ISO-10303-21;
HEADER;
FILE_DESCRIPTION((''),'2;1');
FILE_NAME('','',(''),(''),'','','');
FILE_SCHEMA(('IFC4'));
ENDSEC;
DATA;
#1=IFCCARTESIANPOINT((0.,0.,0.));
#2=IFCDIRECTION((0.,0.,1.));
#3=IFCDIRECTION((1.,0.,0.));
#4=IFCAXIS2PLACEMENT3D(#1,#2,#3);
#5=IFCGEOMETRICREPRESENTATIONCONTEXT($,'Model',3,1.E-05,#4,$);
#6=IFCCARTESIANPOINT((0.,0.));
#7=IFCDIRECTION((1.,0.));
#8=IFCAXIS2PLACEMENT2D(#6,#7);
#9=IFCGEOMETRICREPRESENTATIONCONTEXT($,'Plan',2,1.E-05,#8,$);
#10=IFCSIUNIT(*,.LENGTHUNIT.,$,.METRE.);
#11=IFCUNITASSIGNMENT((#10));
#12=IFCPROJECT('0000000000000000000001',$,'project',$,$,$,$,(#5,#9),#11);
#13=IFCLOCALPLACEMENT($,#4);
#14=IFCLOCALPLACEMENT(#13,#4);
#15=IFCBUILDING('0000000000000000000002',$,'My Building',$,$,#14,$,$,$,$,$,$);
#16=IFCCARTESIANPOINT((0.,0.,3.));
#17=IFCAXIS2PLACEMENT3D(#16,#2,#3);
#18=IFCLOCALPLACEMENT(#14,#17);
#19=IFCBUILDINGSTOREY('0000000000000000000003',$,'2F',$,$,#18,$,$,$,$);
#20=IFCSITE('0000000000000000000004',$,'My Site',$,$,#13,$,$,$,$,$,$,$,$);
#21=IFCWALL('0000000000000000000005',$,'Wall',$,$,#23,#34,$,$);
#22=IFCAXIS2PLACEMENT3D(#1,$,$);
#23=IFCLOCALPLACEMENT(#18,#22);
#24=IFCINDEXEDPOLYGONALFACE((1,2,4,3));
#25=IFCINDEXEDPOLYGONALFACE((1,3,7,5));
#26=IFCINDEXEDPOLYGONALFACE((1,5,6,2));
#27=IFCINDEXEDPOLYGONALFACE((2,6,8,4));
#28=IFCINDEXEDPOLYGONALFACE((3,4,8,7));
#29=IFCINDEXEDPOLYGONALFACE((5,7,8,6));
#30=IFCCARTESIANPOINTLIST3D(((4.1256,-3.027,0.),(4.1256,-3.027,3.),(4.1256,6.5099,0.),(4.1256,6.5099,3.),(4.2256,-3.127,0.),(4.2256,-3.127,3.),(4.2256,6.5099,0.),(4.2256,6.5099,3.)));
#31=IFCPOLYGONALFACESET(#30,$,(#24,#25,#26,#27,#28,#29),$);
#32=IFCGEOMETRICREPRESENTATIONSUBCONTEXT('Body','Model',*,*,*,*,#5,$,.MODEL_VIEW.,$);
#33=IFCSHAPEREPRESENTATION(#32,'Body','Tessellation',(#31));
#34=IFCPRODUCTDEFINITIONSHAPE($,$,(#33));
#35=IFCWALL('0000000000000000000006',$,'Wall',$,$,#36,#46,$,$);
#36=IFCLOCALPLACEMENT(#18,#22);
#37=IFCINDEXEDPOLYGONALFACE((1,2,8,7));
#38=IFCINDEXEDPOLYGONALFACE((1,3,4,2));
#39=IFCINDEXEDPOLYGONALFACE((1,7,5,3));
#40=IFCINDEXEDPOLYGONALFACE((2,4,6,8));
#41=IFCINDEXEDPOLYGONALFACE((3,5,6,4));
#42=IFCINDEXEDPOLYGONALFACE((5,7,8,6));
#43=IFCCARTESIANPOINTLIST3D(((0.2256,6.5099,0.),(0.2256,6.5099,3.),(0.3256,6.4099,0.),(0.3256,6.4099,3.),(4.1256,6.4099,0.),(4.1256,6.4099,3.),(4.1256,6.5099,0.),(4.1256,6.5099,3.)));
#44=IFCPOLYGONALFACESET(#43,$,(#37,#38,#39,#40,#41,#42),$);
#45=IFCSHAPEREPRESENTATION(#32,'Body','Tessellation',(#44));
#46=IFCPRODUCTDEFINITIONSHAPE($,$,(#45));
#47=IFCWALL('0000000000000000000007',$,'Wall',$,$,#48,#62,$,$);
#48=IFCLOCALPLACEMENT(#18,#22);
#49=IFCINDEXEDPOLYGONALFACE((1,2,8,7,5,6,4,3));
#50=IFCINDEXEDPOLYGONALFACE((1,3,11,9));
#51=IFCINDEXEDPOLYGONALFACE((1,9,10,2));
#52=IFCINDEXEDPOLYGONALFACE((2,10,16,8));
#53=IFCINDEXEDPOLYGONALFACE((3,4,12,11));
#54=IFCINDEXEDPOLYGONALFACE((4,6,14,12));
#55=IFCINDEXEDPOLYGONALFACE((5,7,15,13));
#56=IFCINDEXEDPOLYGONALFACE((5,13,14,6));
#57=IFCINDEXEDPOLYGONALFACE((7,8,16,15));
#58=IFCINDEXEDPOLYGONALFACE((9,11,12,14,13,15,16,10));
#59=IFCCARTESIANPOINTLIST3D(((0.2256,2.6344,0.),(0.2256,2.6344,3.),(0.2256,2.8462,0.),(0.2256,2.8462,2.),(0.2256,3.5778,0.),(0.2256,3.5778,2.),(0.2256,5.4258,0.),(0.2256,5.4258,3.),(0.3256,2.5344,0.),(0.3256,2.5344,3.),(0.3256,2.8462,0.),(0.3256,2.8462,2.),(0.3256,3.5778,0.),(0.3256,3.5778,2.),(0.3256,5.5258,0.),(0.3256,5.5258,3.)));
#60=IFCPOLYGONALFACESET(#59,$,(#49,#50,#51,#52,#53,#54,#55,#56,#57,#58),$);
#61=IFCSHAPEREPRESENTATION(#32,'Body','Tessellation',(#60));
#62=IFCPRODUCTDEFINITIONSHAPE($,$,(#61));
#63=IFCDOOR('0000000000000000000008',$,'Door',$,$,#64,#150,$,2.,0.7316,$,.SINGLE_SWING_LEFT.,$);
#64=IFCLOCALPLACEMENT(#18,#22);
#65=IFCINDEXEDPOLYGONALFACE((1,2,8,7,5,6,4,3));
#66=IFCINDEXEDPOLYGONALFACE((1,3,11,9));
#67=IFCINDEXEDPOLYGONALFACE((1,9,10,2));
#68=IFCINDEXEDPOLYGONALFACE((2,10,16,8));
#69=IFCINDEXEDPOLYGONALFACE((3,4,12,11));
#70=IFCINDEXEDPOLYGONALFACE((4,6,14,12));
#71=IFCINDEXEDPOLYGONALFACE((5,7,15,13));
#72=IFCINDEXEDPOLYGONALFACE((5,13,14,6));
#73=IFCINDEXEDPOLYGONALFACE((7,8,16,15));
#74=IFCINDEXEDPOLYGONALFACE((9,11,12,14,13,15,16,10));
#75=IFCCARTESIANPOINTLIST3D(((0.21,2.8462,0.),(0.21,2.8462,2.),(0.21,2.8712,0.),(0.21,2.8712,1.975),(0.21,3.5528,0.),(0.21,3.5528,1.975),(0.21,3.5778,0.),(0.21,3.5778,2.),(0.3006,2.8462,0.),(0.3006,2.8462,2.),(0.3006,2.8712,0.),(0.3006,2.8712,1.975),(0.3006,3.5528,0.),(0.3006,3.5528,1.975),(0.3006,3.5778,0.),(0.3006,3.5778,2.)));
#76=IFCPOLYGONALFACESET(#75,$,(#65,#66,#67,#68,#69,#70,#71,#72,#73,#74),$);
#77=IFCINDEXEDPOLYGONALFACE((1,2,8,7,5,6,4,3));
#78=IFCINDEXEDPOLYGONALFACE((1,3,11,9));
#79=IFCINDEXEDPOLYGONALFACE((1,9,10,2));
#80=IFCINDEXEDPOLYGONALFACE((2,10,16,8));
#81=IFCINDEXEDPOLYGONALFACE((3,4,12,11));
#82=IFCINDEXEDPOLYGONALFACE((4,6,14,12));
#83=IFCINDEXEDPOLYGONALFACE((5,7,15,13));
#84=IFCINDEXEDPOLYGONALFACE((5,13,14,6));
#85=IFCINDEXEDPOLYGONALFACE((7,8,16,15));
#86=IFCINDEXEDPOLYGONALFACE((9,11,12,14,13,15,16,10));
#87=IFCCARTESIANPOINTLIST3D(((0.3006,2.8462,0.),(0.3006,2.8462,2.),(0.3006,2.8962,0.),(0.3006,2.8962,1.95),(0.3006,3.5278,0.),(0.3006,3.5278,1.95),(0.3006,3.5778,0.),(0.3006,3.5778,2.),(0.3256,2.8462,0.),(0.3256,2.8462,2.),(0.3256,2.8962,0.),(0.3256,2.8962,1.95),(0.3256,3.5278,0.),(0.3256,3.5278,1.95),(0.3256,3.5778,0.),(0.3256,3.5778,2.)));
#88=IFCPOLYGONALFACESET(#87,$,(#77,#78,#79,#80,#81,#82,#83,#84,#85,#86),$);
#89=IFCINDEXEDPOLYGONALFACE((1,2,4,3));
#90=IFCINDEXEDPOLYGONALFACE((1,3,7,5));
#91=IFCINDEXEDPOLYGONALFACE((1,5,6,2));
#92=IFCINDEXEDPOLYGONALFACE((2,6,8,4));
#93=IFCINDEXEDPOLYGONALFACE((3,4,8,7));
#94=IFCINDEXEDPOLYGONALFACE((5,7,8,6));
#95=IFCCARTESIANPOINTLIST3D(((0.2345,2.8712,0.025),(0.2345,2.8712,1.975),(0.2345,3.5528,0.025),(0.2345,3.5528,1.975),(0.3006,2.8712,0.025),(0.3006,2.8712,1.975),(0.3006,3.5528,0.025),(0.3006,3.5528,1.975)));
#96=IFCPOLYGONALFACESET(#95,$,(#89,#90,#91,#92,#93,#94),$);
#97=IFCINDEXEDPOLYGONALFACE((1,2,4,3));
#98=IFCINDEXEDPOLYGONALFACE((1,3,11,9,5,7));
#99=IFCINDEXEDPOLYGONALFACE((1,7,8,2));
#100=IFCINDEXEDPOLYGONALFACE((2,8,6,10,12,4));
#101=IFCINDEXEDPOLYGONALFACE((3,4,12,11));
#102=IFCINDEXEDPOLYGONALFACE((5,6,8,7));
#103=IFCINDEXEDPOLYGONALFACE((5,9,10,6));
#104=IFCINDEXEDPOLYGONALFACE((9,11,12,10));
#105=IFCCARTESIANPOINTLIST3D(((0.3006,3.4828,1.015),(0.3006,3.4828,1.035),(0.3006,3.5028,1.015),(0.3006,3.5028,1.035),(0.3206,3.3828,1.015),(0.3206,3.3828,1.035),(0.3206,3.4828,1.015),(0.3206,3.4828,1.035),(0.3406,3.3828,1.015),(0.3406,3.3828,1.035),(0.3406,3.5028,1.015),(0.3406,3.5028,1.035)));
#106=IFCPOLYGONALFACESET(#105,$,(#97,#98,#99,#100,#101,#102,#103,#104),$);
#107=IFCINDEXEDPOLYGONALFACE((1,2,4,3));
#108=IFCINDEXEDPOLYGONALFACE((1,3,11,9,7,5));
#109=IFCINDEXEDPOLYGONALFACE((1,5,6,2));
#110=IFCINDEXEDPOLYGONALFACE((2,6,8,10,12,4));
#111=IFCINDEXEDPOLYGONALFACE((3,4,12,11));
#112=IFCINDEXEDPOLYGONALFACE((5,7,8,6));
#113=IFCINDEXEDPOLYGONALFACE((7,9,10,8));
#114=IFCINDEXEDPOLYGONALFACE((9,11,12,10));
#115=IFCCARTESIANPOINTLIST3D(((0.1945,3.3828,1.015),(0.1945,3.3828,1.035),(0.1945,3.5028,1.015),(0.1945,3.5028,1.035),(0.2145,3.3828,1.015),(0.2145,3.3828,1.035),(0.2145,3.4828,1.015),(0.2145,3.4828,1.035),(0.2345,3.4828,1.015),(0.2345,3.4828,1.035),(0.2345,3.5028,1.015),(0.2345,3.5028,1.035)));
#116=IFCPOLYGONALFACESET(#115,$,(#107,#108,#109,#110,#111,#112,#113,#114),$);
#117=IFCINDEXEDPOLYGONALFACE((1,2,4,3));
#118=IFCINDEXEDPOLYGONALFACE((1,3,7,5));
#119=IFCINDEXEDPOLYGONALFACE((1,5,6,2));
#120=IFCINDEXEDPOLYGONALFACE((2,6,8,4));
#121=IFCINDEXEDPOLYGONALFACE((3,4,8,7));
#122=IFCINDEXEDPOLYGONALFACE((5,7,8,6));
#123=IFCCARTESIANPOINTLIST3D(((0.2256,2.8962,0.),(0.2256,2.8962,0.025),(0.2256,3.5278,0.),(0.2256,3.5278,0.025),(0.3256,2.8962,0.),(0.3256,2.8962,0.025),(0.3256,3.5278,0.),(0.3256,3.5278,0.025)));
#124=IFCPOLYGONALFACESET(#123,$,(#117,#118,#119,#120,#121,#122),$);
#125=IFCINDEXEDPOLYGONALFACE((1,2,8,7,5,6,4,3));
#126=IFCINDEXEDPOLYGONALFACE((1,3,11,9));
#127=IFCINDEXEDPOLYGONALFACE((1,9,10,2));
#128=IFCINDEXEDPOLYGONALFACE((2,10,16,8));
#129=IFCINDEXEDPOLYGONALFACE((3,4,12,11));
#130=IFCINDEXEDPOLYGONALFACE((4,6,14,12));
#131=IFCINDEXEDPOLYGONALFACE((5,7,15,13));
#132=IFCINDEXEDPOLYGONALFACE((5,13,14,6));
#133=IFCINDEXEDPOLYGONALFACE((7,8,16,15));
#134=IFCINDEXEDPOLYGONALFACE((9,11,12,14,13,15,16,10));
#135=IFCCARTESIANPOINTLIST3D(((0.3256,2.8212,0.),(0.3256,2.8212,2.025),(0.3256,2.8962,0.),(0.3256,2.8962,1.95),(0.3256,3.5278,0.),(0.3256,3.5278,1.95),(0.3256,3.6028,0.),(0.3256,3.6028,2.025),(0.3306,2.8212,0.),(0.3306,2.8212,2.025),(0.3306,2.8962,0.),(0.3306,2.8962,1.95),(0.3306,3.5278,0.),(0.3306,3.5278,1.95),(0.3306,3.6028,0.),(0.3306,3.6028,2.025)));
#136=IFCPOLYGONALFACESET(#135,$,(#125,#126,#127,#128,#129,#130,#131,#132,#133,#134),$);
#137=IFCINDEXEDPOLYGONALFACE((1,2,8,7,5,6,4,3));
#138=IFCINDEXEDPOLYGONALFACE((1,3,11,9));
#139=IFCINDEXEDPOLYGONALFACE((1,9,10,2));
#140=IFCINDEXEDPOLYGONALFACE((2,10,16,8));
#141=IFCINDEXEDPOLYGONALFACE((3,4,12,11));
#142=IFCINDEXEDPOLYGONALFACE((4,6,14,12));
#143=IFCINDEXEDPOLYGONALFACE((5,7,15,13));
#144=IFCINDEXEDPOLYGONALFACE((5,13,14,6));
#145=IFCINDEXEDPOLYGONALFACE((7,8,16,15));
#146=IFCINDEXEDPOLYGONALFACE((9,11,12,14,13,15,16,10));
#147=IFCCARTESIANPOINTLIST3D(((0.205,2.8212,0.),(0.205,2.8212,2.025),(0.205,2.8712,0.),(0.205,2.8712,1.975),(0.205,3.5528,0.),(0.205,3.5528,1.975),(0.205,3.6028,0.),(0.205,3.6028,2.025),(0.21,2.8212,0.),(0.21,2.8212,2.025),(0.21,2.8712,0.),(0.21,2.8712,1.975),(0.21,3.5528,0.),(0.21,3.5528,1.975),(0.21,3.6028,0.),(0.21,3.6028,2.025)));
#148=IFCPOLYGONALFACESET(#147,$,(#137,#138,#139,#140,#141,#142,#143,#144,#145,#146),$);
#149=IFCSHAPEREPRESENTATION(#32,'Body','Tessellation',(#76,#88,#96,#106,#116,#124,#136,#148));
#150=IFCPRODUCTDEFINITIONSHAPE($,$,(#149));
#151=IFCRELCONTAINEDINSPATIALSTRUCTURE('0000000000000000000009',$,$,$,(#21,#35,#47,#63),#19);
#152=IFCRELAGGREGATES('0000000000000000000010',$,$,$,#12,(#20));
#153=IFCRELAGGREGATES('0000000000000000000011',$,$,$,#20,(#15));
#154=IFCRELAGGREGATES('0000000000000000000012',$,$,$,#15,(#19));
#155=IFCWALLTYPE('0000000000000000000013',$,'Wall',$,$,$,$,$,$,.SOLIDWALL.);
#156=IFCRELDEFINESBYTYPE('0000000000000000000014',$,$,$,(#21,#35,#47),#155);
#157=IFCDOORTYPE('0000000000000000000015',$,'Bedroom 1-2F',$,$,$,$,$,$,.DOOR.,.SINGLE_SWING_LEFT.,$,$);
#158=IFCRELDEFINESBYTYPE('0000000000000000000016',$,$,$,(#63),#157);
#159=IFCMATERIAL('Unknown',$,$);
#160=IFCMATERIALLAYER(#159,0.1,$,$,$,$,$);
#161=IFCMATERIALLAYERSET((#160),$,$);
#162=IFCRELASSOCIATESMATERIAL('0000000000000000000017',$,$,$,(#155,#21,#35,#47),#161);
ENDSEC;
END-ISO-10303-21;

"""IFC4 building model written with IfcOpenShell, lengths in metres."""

from ifc_helpers import new_model, entity, si_unit, frame, origin_with_axes, origin_2d_with_axis, place, context, subcontext, project, spatial, line, indexed_curve, outline, extrude, shape, source, transform, mapped, material, layer, layer_set, layer_usage, type_object, type_shapes, element, fill, save


model = new_model("IFC4")

# Units and contexts
model_context = context("Model", 3, precision=1e-05, world=origin_with_axes())
plan_context = context("Plan", 2, precision=1e-05, world=origin_2d_with_axis())
body_context_1 = subcontext(model_context, "Body", "Model", "MODEL_VIEW")
body_context_2 = subcontext(plan_context, "Body", "Plan", "PLAN_VIEW")
ifc_project = project(units=[si_unit("LENGTHUNIT", "METRE")], contexts=[model_context, plan_context])

# Site, building, storey
site_placement = place(None, origin_with_axes())
site = spatial("IfcSite", under=ifc_project, at=site_placement, Name="My Site")
building_placement = place(site_placement, origin_with_axes())
building = spatial("IfcBuilding", under=site, at=building_placement, Name="My Building")
storey_placement = place(building_placement, frame((0.0, 0.0, 3.0), z_axis=(0.0, 0.0, 1.0), x_axis=(1.0, 0.0, 0.0)))
storey = spatial("IfcBuildingStorey", under=building, at=storey_placement, Name="2F")

# Walls
ifc_material = material(Name="Unknown")
ifc_layer = layer(ifc_material, 0.1)
ifc_layer_set = layer_set([ifc_layer])
ifc_layer_usage_1 = layer_usage(ifc_layer_set, "AXIS2", "POSITIVE", 0.0)
wall_type = type_object("IfcWallType", Name="Wall", PredefinedType="SOLIDWALL", material=ifc_layer_set)
wall_1_placement = place(storey_placement, frame((4.2256, -3.127, 0.0), z_axis=(0.0, 0.0, 1.0), x_axis=(0.0, 1.0, 0.0)))
element("IfcWall", 1, at=wall_1_placement, inside=storey, type_object=wall_type, material=ifc_layer_usage_1, Name="Wall", context=body_context_1, shape_type="SweptSolid", body=[
    extrude(outline(indexed_curve([(0.0, 0.0), (0.1, 0.1), (9.6369, 0.1), (9.6369, 0.0)], segments=[line(1, 2, 3, 4, 1)])), origin_with_axes(), (0.0, 0.0, 1.0), 3.0),
])
ifc_layer_usage_2 = layer_usage(ifc_layer_set, "AXIS2", "POSITIVE", 0.0)
wall_2_placement = place(storey_placement, frame((4.1256, 6.5099, 0.0), z_axis=(0.0, 0.0, 1.0), x_axis=(-1.0, 0.0, 0.0)))
element("IfcWall", 2, at=wall_2_placement, inside=storey, type_object=wall_type, material=ifc_layer_usage_2, Name="Wall", context=body_context_1, shape_type="SweptSolid", body=[
    extrude(outline(indexed_curve([(0.0, 0.0), (0.0, 0.1), (3.8, 0.1), (3.9, 0.0)], segments=[line(1, 2, 3, 4, 1)])), origin_with_axes(), (0.0, 0.0, 1.0), 3.0),
])

# Wall, opening, door
ifc_layer_usage_3 = layer_usage(ifc_layer_set, "AXIS2", "POSITIVE", 0.0)
wall_3_placement = place(storey_placement, frame((0.2256, 5.5258, 0.0), z_axis=(0.0, 0.0, 1.0), x_axis=(0.0, -1.0, 0.0)))
wall_3 = element("IfcWall", 3, at=wall_3_placement, inside=storey, type_object=wall_type, material=ifc_layer_usage_3, Name="Wall", context=body_context_1, shape_type="SweptSolid", body=[
    extrude(outline(indexed_curve([(0.1, 0.0), (0.0, 0.1), (2.9914, 0.1), (2.8914, 0.0)], segments=[line(1, 2, 3, 4, 1)])), origin_with_axes(), (0.0, 0.0, 1.0), 3.0),
])
shared_shape_1 = source(origin_with_axes(), body_context_1, "Body", "SweptSolid", [
    extrude(outline(indexed_curve([(0.0, 0.0), (0.7316, 0.0), (0.7316, 2.0), (0.0, 2.0)], segments=[line(1, 2, 3, 4, 1)])), frame((0.0, -0.6, 0.0), z_axis=(0.0, -1.0, 0.0), x_axis=(1.0, 0.0, 0.0)), (0.0, 0.0, -1.0), 1.2),
])
opening_1_placement = place(wall_3_placement, frame((2.6795, 0.1, 0.0), z_axis=(0.0, 0.0, 1.0), x_axis=(-1.0, 0.0, 0.0)))
opening_1 = element("IfcOpeningElement", 4, at=opening_1_placement, cuts=wall_3, PredefinedType="OPENING", context=body_context_1, shape_type="MappedRepresentation", body=[
    mapped(shared_shape_1, transform((0.0, 0.0, 0.0), x_axis=(1.0, 0.0, 0.0), y_axis=(0.0, 1.0, 0.0), z_axis=(0.0, 0.0, 1.0), scale=1.0)),
])
door_type_1 = type_object("IfcDoorType", Name="Bedroom 1-2F", OperationType="SINGLE_SWING_LEFT", PredefinedType="DOOR")
shared_shape_2 = source(origin_with_axes(), body_context_1, "Body", "SweptSolid", [
    extrude(outline(indexed_curve([(0.0, 0.0), (0.0, 2.0), (0.7316, 2.0), (0.7316, 0.0), (0.7066, 0.0), (0.7066, 1.975), (0.025, 1.975), (0.025, 0.0)], segments=[line(1, 2, 3, 4, 5, 6, 7, 8, 1)])), frame((0.0, 0.025, 0.0), z_axis=(0.0, -1.0, 0.0), x_axis=(1.0, 0.0, 0.0)), (0.0, 0.0, -1.0), 0.0906),
    extrude(outline(indexed_curve([(0.0, 0.0), (0.0, 2.0), (0.7316, 2.0), (0.7316, 0.0), (0.6816, 0.0), (0.6816, 1.95), (0.05, 1.95), (0.05, 0.0)], segments=[line(1, 2, 3, 4, 5, 6, 7, 8, 1)])), frame((0.0, 0.0, 0.0), z_axis=(0.0, -1.0, 0.0), x_axis=(1.0, 0.0, 0.0)), (0.0, 0.0, -1.0), 0.025),
    extrude(outline(indexed_curve([(0.0, 0.0), (0.6816, 0.0), (0.6816, 0.0661), (0.0, 0.0661)], segments=[line(1, 2, 3, 4, 1)])), frame((0.025, 0.025, 0.025), z_axis=(0.0, 0.0, 1.0), x_axis=(1.0, 0.0, 0.0)), (0.0, 0.0, 1.0), 1.95),
    extrude(outline(indexed_curve([(0.0, 0.0), (0.0, -0.04), (-0.12, -0.04), (-0.12, -0.02), (-0.02, -0.02), (-0.02, 0.0)], segments=[line(1, 2, 3, 4, 5, 6, 1)])), frame((0.6566, 0.025, 1.015), z_axis=(0.0, 0.0, 1.0), x_axis=(1.0, 0.0, 0.0)), (0.0, 0.0, 1.0), 0.02),
    extrude(outline(indexed_curve([(0.0, 0.0), (0.0, 0.04), (-0.12, 0.04), (-0.12, 0.02), (-0.02, 0.02), (-0.02, 0.0)], segments=[line(1, 2, 3, 4, 5, 6, 1)])), frame((0.6566, 0.0911, 1.015), z_axis=(0.0, 0.0, 1.0), x_axis=(1.0, 0.0, 0.0)), (0.0, 0.0, 1.0), 0.02),
    extrude(outline(indexed_curve([(0.0, 0.0), (0.6316, 0.0), (0.6316, 0.1), (0.0, 0.1)], segments=[line(1, 2, 3, 4, 1)])), frame((0.05, 0.0, 0.0), z_axis=(0.0, 0.0, 1.0), x_axis=(1.0, 0.0, 0.0)), (0.0, 0.0, 1.0), 0.025),
    extrude(outline(indexed_curve([(0.0, 0.0), (0.0, 2.025), (0.7816, 2.025), (0.7816, 0.0), (0.7066, 0.0), (0.7066, 1.95), (0.075, 1.95), (0.075, 0.0)], segments=[line(1, 2, 3, 4, 5, 6, 7, 8, 1)])), frame((-0.025, -0.005, 0.0), z_axis=(0.0, -1.0, 0.0), x_axis=(1.0, 0.0, 0.0)), (0.0, 0.0, -1.0), 0.005),
    extrude(outline(indexed_curve([(0.0, 0.0), (0.0, 2.025), (0.7816, 2.025), (0.7816, 0.0), (0.7316, 0.0), (0.7316, 1.975), (0.05, 1.975), (0.05, 0.0)], segments=[line(1, 2, 3, 4, 5, 6, 7, 8, 1)])), frame((-0.025, 0.1156, 0.0), z_axis=(0.0, -1.0, 0.0), x_axis=(1.0, 0.0, 0.0)), (0.0, 0.0, -1.0), 0.005),
])
shared_shape_3 = source(origin_with_axes(), body_context_2, "Body", "Curve2D", [
    entity("IfcIndexedPolyCurve", entity("IfcCartesianPointList2D", [[0.0, 0.0], [0.0, 0.1156], [0.025, 0.1156], [0.025, 0.025], [0.05, 0.025], [0.05, 0.0]]), [entity("IfcLineIndex", [1, 2, 3, 4, 5, 6, 1])]),
    entity("IfcIndexedPolyCurve", entity("IfcCartesianPointList2D", [[0.7316, 0.0], [0.7316, 0.1156], [0.7066, 0.1156], [0.7066, 0.025], [0.6816, 0.025], [0.6816, 0.0]]), [entity("IfcLineIndex", [1, 2, 3, 4, 5, 6, 1])]),
    entity("IfcTrimmedCurve", entity("IfcEllipse", entity("IfcAxis2Placement2D", entity("IfcCartesianPoint", [0.0911, 0.1156]), entity("IfcDirection", [1.0, 0.0])), 0.6155, 0.6816), [entity("IfcCartesianPoint", [0.7066, 0.1156])], [entity("IfcCartesianPoint", [0.0911, 0.7972])], True, "CARTESIAN"),
    entity("IfcIndexedPolyCurve", entity("IfcCartesianPointList2D", [[0.025, 0.1156], [0.0911, 0.1156], [0.0911, 0.7972], [0.025, 0.7972]]), [entity("IfcLineIndex", [1, 2, 3, 4, 1])]),
])
type_shapes(door_type_1, [shared_shape_2, shared_shape_3])
door_1_placement = place(opening_1_placement, frame((0.0, 0.0, 0.0), z_axis=(0.0, 0.0, 1.0), x_axis=(1.0, 0.0, 0.0)))
door_1 = element("IfcDoor", 5, at=door_1_placement, inside=storey, type_object=door_type_1, Name="Door", OperationType="SINGLE_SWING_LEFT", OverallHeight=2.0, OverallWidth=0.7316, shapes=[
    shape(body_context_1, "Body", "MappedRepresentation", [mapped(shared_shape_2, transform((0.0, 0.0, 0.0), x_axis=(1.0, 0.0, 0.0), y_axis=(0.0, 1.0, 0.0), z_axis=(0.0, 0.0, 1.0), scale=1.0))]),
    shape(body_context_2, "Body", "MappedRepresentation", [mapped(shared_shape_3, transform((0.0, 0.0, 0.0), x_axis=(1.0, 0.0, 0.0), y_axis=(0.0, 1.0, 0.0), z_axis=(0.0, 0.0, 1.0), scale=1.0))]),
])
fill(opening_1, door_1)

save(model, "model.ifc")
